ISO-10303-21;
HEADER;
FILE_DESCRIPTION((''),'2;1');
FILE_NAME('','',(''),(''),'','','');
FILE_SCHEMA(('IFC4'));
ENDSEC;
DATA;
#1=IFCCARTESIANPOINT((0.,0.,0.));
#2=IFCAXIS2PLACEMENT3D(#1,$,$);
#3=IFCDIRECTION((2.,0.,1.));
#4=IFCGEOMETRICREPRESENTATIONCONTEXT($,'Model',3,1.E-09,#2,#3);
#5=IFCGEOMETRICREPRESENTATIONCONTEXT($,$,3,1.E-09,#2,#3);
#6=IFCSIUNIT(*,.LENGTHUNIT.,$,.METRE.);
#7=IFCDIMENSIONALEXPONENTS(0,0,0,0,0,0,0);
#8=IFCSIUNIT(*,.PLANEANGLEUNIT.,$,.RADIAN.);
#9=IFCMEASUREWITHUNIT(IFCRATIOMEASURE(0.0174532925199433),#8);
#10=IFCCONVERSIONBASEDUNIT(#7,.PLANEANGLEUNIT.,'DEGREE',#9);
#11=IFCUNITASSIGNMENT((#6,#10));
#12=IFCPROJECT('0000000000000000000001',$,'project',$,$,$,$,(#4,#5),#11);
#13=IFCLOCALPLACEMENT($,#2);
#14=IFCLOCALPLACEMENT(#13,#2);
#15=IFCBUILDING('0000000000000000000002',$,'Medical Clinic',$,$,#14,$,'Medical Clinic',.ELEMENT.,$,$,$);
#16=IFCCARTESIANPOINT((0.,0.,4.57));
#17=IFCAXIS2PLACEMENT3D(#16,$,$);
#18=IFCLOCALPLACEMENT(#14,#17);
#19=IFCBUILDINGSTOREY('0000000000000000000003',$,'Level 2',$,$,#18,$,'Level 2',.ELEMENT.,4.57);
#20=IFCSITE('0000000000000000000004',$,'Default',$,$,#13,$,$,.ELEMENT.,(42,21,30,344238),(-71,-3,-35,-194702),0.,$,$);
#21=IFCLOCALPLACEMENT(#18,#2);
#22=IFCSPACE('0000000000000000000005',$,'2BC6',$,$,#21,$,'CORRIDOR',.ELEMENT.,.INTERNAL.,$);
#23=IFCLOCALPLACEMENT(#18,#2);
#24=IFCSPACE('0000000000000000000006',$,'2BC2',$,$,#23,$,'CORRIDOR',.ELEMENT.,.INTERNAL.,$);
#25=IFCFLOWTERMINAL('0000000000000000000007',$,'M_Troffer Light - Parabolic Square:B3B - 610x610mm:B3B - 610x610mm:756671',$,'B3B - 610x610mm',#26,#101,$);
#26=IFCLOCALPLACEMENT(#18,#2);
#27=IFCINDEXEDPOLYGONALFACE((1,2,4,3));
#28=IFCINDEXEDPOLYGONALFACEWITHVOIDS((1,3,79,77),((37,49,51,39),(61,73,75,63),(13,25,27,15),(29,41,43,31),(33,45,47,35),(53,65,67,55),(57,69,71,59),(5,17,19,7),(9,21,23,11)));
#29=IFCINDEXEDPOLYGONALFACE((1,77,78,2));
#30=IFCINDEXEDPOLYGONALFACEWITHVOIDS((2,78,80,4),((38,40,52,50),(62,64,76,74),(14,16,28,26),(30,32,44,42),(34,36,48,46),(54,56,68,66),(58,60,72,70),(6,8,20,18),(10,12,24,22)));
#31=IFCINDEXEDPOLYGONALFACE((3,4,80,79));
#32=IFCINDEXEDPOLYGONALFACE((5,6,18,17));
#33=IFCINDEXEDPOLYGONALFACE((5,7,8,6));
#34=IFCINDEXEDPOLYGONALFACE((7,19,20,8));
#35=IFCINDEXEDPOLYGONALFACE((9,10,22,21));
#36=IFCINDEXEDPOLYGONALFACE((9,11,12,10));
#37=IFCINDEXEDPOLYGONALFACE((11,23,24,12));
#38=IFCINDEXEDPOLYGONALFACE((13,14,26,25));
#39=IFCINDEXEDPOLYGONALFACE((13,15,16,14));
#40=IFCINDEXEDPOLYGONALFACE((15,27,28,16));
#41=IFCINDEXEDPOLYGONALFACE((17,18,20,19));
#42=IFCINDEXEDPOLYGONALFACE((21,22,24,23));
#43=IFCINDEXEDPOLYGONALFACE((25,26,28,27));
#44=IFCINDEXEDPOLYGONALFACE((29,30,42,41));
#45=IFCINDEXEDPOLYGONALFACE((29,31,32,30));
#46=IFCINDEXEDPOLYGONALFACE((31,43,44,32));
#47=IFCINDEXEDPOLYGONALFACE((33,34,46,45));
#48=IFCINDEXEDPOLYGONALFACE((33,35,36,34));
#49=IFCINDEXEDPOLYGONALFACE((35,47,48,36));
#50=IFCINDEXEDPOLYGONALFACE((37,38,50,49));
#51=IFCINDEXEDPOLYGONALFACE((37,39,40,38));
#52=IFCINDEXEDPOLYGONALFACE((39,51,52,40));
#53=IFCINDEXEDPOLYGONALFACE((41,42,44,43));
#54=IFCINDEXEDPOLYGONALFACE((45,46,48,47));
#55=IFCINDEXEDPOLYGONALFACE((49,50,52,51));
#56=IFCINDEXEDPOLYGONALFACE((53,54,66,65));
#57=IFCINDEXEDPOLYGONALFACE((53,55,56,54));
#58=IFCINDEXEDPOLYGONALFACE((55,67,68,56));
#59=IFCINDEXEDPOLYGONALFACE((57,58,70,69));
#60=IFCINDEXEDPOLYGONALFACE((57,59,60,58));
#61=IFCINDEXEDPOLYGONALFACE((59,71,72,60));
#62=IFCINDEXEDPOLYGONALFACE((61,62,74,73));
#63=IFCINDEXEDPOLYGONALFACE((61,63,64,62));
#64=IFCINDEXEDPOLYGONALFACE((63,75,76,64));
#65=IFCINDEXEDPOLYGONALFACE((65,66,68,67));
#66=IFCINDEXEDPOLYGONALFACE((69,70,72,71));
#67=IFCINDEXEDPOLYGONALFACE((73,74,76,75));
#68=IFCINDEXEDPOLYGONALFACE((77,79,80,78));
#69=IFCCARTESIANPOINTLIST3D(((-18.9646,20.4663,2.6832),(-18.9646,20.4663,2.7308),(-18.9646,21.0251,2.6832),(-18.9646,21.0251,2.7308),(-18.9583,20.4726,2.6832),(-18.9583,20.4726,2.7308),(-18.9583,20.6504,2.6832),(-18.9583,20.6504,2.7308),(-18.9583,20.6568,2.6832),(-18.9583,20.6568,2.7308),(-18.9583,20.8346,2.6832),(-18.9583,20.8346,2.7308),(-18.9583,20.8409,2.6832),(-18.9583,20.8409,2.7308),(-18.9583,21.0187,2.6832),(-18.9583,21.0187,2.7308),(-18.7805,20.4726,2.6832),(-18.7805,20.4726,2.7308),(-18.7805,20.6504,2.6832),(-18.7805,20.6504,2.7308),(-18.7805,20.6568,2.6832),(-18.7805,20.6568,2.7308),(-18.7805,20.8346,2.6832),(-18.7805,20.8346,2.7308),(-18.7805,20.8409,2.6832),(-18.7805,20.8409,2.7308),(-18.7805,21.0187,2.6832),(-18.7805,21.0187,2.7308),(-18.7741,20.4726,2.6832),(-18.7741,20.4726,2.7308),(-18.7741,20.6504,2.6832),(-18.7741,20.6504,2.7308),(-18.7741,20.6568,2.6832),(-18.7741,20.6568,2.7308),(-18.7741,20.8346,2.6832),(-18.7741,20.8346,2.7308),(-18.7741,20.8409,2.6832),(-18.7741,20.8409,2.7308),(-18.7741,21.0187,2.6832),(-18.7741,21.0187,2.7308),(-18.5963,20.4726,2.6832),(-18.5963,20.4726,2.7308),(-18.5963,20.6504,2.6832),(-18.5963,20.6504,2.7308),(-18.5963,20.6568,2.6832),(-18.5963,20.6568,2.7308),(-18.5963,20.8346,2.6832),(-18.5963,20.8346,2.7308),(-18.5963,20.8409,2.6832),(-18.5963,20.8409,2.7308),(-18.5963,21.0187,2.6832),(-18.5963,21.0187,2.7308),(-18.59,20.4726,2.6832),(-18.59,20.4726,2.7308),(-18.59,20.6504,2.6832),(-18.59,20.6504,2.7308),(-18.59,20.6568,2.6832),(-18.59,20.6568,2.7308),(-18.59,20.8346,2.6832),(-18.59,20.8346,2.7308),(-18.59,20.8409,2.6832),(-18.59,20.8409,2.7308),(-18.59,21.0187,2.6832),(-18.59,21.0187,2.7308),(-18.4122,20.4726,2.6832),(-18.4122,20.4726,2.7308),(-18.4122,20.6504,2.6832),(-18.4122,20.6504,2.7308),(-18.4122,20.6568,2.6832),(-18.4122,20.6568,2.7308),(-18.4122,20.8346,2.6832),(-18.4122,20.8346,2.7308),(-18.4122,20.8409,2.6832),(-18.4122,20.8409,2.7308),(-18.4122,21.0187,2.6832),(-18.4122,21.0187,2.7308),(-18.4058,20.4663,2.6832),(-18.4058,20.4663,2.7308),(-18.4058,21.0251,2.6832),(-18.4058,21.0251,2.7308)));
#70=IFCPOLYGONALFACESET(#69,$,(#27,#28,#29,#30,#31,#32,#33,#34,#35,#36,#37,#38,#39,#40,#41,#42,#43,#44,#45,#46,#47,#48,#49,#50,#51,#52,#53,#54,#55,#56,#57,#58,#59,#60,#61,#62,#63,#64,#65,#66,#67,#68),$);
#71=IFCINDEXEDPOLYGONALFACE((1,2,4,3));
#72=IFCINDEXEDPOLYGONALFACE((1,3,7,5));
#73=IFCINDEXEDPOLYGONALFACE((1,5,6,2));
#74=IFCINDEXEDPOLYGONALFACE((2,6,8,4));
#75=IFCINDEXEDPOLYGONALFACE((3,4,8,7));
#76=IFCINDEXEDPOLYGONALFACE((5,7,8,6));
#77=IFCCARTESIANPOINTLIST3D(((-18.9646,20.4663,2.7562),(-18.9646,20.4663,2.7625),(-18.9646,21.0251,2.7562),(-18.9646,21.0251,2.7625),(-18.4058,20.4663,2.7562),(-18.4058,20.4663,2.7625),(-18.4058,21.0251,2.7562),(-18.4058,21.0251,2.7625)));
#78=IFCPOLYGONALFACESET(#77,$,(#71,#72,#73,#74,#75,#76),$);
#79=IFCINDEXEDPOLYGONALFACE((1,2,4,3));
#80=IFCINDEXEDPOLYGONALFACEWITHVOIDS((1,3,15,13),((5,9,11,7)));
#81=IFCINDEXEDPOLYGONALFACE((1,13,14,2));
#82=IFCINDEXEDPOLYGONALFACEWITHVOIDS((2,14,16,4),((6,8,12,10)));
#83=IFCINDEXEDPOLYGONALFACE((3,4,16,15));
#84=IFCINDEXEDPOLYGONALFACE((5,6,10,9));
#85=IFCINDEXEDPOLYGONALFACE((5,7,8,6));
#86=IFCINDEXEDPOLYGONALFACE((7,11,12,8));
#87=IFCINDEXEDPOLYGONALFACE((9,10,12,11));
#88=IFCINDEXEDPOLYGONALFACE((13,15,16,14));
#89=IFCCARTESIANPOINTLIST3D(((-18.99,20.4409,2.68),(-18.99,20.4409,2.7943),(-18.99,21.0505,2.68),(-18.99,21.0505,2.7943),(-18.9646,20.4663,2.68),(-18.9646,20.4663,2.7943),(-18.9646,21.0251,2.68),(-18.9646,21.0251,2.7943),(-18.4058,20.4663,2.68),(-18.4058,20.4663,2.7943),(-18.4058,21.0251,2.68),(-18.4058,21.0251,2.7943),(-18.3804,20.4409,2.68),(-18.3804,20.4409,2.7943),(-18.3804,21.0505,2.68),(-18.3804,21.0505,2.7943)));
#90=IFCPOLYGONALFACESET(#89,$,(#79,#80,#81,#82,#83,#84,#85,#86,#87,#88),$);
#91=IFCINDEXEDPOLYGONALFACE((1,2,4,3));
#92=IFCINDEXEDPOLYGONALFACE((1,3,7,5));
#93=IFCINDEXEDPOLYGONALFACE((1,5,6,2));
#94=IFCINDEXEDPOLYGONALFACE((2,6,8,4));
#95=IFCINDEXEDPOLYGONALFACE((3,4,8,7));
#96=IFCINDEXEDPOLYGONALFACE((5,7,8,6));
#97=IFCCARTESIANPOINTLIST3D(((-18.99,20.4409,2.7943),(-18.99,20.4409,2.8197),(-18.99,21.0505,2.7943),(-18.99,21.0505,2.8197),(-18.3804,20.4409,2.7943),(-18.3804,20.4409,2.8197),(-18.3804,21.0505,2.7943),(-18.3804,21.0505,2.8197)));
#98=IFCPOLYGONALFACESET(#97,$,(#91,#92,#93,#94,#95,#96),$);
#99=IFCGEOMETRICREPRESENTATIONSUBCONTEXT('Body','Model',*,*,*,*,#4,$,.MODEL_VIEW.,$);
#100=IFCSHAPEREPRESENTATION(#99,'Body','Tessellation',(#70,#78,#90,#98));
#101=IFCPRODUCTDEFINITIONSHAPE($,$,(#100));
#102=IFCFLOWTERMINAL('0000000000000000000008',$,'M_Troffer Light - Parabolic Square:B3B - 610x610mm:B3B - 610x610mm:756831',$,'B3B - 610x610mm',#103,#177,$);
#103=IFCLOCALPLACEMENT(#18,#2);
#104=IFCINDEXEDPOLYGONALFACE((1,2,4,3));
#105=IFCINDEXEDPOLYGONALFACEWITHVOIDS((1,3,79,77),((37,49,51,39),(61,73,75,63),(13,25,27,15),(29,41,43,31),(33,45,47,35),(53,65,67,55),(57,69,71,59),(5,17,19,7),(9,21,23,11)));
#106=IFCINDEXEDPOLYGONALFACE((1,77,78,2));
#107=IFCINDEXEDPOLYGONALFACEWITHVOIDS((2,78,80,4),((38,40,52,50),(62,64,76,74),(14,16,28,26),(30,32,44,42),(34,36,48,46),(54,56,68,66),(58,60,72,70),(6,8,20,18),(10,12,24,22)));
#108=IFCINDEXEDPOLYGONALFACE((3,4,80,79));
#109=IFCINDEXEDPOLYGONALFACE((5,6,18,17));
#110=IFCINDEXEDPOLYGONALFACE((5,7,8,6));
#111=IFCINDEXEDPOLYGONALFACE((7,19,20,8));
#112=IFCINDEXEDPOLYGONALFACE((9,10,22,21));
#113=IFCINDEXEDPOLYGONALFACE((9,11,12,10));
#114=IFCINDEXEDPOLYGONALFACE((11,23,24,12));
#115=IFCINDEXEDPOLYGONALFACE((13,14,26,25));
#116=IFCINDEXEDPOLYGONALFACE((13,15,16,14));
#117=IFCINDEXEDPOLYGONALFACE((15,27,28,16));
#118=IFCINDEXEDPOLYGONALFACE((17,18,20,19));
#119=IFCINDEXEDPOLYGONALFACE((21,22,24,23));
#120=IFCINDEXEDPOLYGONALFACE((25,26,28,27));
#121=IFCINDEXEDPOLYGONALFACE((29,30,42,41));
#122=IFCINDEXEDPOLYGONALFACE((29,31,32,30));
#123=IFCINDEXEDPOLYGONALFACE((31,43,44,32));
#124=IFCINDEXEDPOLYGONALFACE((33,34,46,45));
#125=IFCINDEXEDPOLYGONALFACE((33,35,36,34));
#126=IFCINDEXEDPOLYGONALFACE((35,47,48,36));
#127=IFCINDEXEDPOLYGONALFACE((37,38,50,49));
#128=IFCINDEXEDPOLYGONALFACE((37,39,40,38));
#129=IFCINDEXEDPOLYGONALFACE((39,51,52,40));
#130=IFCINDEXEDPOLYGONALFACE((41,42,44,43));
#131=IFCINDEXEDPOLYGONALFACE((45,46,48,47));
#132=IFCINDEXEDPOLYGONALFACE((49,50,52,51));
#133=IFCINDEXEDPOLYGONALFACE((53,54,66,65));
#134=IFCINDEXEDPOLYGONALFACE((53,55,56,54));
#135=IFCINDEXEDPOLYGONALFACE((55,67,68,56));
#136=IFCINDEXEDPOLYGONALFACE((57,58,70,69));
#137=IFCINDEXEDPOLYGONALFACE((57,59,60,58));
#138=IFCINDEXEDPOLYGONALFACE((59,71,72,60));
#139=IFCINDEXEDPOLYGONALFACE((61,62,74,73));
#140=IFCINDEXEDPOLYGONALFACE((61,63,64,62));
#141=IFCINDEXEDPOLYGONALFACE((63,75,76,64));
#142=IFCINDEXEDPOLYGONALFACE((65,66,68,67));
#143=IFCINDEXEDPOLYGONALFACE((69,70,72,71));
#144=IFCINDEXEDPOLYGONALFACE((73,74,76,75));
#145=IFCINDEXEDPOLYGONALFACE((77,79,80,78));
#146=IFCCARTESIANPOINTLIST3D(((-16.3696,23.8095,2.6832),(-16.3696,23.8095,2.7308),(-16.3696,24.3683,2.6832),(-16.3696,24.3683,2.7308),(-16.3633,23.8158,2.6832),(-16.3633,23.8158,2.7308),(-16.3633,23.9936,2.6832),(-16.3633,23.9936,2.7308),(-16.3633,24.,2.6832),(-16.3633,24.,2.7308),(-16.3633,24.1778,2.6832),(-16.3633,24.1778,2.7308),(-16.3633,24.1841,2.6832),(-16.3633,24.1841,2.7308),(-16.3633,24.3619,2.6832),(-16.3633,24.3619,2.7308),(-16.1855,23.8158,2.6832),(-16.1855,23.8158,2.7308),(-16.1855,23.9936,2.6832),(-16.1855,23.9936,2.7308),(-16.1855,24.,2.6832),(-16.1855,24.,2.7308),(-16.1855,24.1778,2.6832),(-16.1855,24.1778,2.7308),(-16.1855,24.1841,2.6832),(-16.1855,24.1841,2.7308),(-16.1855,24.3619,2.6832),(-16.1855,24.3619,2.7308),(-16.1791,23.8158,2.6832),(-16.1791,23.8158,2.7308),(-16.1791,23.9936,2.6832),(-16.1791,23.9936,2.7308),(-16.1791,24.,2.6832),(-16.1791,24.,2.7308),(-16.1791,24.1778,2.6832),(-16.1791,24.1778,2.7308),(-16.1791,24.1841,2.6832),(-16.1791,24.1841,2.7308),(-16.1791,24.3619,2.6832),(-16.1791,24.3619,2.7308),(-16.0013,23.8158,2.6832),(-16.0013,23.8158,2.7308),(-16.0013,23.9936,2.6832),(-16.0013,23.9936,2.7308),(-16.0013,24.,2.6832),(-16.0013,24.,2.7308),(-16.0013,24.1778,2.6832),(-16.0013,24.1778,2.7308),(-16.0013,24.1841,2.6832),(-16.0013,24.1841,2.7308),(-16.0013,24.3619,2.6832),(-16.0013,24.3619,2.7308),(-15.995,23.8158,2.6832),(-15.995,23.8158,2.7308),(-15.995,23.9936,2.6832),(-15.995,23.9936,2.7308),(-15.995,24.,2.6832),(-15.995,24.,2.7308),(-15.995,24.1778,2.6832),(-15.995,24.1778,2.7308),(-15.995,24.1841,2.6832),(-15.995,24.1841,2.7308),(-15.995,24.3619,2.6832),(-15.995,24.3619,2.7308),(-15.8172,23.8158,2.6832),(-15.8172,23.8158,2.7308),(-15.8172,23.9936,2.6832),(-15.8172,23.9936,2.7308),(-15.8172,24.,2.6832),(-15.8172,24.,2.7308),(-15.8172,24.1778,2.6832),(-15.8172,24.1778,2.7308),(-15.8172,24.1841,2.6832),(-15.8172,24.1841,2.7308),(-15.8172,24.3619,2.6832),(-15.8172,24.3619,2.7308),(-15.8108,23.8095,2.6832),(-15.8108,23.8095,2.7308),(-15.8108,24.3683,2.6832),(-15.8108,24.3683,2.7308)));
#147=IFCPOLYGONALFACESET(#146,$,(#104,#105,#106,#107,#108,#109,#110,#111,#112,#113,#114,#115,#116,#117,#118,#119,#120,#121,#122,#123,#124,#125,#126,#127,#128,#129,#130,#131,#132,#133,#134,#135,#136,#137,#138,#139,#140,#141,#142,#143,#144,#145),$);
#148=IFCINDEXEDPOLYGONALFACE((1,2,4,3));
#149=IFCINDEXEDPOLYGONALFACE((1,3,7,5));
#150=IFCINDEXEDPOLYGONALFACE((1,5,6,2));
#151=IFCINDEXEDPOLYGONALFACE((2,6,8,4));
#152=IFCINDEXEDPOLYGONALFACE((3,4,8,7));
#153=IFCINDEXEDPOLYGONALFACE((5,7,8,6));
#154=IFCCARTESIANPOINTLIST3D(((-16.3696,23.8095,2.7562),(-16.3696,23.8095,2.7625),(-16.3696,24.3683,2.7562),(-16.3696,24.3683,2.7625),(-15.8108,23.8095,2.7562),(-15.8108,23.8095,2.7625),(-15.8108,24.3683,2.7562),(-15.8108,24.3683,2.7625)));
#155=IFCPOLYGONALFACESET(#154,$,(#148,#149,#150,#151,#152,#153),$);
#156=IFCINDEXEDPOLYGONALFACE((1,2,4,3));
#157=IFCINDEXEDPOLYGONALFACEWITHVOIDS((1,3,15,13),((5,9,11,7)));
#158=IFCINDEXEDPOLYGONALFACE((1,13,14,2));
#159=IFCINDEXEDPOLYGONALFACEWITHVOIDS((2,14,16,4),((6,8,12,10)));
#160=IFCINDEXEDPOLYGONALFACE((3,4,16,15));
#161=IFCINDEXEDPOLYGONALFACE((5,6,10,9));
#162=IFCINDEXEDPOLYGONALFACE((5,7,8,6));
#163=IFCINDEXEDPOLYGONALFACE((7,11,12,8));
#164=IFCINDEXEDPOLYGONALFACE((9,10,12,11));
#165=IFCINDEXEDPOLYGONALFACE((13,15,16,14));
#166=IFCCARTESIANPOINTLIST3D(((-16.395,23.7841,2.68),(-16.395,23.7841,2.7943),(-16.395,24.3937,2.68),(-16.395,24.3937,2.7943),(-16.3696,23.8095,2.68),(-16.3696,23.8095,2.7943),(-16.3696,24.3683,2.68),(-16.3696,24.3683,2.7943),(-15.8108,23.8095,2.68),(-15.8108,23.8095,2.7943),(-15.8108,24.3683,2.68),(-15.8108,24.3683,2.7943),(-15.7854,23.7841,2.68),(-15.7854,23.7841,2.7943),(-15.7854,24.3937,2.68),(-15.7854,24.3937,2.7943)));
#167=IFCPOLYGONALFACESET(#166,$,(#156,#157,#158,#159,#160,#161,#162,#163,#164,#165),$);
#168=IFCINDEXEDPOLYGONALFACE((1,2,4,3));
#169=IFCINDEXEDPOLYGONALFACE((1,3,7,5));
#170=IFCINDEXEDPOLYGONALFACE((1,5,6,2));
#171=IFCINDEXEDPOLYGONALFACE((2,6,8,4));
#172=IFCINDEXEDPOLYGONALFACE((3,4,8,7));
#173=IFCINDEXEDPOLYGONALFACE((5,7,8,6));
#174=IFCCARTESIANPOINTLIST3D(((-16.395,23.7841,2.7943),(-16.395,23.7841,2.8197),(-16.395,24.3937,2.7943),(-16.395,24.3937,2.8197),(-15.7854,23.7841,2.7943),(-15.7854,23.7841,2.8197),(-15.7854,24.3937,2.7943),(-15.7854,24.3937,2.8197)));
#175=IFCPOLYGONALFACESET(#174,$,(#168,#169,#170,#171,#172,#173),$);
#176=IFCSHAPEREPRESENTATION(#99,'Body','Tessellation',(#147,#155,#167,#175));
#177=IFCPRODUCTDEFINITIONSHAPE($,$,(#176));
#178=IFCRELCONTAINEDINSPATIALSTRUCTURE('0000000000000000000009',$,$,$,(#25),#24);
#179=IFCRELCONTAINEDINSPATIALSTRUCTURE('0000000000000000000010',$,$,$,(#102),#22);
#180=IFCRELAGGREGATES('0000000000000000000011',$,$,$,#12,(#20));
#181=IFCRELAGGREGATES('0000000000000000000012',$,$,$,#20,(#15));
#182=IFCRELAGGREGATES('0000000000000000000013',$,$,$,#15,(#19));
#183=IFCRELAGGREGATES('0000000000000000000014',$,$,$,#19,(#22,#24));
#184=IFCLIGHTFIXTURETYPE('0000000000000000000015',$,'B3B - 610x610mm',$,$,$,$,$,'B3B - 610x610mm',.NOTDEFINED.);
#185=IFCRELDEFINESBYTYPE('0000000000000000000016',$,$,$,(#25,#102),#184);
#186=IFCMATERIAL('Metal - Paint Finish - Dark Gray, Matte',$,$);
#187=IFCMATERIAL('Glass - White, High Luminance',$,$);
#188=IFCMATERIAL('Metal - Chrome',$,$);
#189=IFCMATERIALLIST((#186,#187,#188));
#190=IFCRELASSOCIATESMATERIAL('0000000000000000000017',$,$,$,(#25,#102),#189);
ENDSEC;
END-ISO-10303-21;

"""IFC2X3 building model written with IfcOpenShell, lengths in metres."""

from ifc_helpers import new_model, entity, si_unit, converted_unit, direction, frame, origin, origin_2d_with_axis, place, context, subcontext, project, spatial, polyline, rectangle, outline, extrude, source, transform, mapped, material, material_list, type_object, type_shapes, element, save


model = new_model("IFC2X3")

# Units and contexts
model_context = context("Model", 3, precision=1e-09, world=origin(), true_north=direction((2.0, 0.0, 1.0)))
context_of_model = context(None, 3, precision=1e-09, world=origin(), true_north=direction((2.0, 0.0, 1.0)))
body_context = subcontext(model_context, "Body", "Model", "MODEL_VIEW")
ifc_project = project(units=[si_unit("LENGTHUNIT", "METRE"), converted_unit("PLANEANGLEUNIT", "DEGREE", entity("IfcRatioMeasure", 0.0174532925199433), si_unit("PLANEANGLEUNIT", "RADIAN"), dimensions=[0, 0, 0, 0, 0, 0, 0])], contexts=[model_context, context_of_model])

# Site, building, storey
site_placement = place(None, origin())
site = spatial("IfcSite", under=ifc_project, at=site_placement, Name="Default", CompositionType="ELEMENT", RefLatitude=(42, 21, 30, 344238), RefLongitude=(-71, -3, -35, -194702), RefElevation=0.0)
building_placement = place(site_placement, origin())
building = spatial("IfcBuilding", under=site, at=building_placement, Name="Medical Clinic", LongName="Medical Clinic", CompositionType="ELEMENT")
storey_placement = place(building_placement, frame((0.0, 0.0, 4.57)))
storey = spatial("IfcBuildingStorey", under=building, at=storey_placement, Name="Level 2", LongName="Level 2", CompositionType="ELEMENT", Elevation=4.57)

# Shared definitions
space_1_placement = place(storey_placement, origin())
space_1 = spatial("IfcSpace", under=storey, at=space_1_placement, Name="2BC6", LongName="CORRIDOR", CompositionType="ELEMENT", InteriorOrExteriorSpace="INTERNAL")

# Shared definitions
space_2_placement = place(storey_placement, origin())
space_2 = spatial("IfcSpace", under=storey, at=space_2_placement, Name="2BC2", LongName="CORRIDOR", CompositionType="ELEMENT", InteriorOrExteriorSpace="INTERNAL")

# Flow terminals
ifc_material_1 = material(Name="Metal - Paint Finish - Dark Gray, Matte")
ifc_material_2 = material(Name="Glass - White, High Luminance")
ifc_material_3 = material(Name="Metal - Chrome")
ifc_material_list_1 = material_list([ifc_material_1, ifc_material_2, ifc_material_3])
light_fixture_type_1 = type_object("IfcLightFixtureType", Name="B3B - 610x610mm", ElementType="B3B - 610x610mm", PredefinedType="NOTDEFINED")
shared_shape_1 = source(origin(), body_context, "Body", "SweptSolid", [
    extrude(outline(polyline([(-0.2794, -0.2794), (0.2794, -0.2794), (0.2794, 0.2794), (-0.2794, 0.2794), (-0.2794, -0.2794)]), holes=[polyline([(-0.0952, 0.0953), (-0.273, 0.0953), (-0.273, 0.2731), (-0.0952, 0.2731), (-0.0952, 0.0953)]), polyline([(0.2731, 0.0953), (0.0953, 0.0953), (0.0953, 0.2731), (0.2731, 0.2731), (0.2731, 0.0953)]), polyline([(-0.0889, 0.2731), (0.0889, 0.2731), (0.0889, 0.0953), (-0.0889, 0.0953), (-0.0889, 0.2731)]), polyline([(0.2731, -0.273), (0.0953, -0.273), (0.0953, -0.0952), (0.2731, -0.0952), (0.2731, -0.273)]), polyline([(0.0889, -0.273), (-0.0889, -0.273), (-0.0889, -0.0952), (0.0889, -0.0952), (0.0889, -0.273)]), polyline([(-0.0952, -0.273), (-0.273, -0.273), (-0.273, -0.0952), (-0.0952, -0.0952), (-0.0952, -0.273)]), polyline([(-0.0952, -0.0889), (-0.273, -0.0889), (-0.273, 0.0889), (-0.0952, 0.0889), (-0.0952, -0.0889)]), polyline([(0.0889, -0.0889), (-0.0889, -0.0889), (-0.0889, 0.0889), (0.0889, 0.0889), (0.0889, -0.0889)]), polyline([(0.2731, -0.0889), (0.0953, -0.0889), (0.0953, 0.0889), (0.2731, 0.0889), (0.2731, -0.0889)])]), frame((0.0, -0.3048, -0.0508), z_axis=(0.0, 0.0, 1.0), x_axis=(-1.0, 0.0, 0.0)), (0.0, 0.0, 1.0), 0.0476),
    extrude(rectangle(XDim=0.5588, YDim=0.5588, at=origin_2d_with_axis()), frame((0.0, -0.3048, -0.0825), z_axis=(0.0, 0.0, 1.0), x_axis=(-1.0, 0.0, 0.0)), (0.0, 0.0, 1.0), 0.0064),
    extrude(outline(polyline([(-0.3048, -0.3048), (0.3048, -0.3048), (0.3048, 0.3048), (-0.3048, 0.3048), (-0.3048, -0.3048)]), holes=[polyline([(0.2794, 0.2794), (0.2794, -0.2794), (-0.2794, -0.2794), (-0.2794, 0.2794), (0.2794, 0.2794)])]), frame((0.0, -0.3048, -0.1143)), (0.0, 0.0, 1.0), 0.1143),
    extrude(rectangle(XDim=0.6096, YDim=0.6096, at=origin_2d_with_axis()), frame((0.0, -0.3048, -0.1397), z_axis=(0.0, 0.0, 1.0), x_axis=(-1.0, 0.0, 0.0)), (0.0, 0.0, 1.0), 0.0254),
])
type_shapes(light_fixture_type_1, [shared_shape_1])
flow_terminal_1_placement = place(space_2_placement, frame((-18.6852, 20.4409, 2.68), z_axis=(0.0, 0.0, -1.0), x_axis=(1.0, 0.0, 0.0)))
element("IfcFlowTerminal", 1, at=flow_terminal_1_placement, inside=space_2, type_object=light_fixture_type_1, material=ifc_material_list_1, Name="M_Troffer Light - Parabolic Square:B3B - 610x610mm:B3B - 610x610mm:756671", ObjectType="B3B - 610x610mm", context=body_context, shape_type="MappedRepresentation", body=[
    mapped(shared_shape_1, transform((0.0, 0.0, 0.0), scale=1.0)),
])
flow_terminal_2_placement = place(space_1_placement, frame((-16.0902, 23.7841, 2.68), z_axis=(0.0, 0.0, -1.0), x_axis=(1.0, 0.0, 0.0)))
element("IfcFlowTerminal", 2, at=flow_terminal_2_placement, inside=space_1, type_object=light_fixture_type_1, material=ifc_material_list_1, Name="M_Troffer Light - Parabolic Square:B3B - 610x610mm:B3B - 610x610mm:756831", ObjectType="B3B - 610x610mm", context=body_context, shape_type="MappedRepresentation", body=[
    mapped(shared_shape_1, transform((0.0, 0.0, 0.0), scale=1.0)),
])

save(model, "model.ifc")
